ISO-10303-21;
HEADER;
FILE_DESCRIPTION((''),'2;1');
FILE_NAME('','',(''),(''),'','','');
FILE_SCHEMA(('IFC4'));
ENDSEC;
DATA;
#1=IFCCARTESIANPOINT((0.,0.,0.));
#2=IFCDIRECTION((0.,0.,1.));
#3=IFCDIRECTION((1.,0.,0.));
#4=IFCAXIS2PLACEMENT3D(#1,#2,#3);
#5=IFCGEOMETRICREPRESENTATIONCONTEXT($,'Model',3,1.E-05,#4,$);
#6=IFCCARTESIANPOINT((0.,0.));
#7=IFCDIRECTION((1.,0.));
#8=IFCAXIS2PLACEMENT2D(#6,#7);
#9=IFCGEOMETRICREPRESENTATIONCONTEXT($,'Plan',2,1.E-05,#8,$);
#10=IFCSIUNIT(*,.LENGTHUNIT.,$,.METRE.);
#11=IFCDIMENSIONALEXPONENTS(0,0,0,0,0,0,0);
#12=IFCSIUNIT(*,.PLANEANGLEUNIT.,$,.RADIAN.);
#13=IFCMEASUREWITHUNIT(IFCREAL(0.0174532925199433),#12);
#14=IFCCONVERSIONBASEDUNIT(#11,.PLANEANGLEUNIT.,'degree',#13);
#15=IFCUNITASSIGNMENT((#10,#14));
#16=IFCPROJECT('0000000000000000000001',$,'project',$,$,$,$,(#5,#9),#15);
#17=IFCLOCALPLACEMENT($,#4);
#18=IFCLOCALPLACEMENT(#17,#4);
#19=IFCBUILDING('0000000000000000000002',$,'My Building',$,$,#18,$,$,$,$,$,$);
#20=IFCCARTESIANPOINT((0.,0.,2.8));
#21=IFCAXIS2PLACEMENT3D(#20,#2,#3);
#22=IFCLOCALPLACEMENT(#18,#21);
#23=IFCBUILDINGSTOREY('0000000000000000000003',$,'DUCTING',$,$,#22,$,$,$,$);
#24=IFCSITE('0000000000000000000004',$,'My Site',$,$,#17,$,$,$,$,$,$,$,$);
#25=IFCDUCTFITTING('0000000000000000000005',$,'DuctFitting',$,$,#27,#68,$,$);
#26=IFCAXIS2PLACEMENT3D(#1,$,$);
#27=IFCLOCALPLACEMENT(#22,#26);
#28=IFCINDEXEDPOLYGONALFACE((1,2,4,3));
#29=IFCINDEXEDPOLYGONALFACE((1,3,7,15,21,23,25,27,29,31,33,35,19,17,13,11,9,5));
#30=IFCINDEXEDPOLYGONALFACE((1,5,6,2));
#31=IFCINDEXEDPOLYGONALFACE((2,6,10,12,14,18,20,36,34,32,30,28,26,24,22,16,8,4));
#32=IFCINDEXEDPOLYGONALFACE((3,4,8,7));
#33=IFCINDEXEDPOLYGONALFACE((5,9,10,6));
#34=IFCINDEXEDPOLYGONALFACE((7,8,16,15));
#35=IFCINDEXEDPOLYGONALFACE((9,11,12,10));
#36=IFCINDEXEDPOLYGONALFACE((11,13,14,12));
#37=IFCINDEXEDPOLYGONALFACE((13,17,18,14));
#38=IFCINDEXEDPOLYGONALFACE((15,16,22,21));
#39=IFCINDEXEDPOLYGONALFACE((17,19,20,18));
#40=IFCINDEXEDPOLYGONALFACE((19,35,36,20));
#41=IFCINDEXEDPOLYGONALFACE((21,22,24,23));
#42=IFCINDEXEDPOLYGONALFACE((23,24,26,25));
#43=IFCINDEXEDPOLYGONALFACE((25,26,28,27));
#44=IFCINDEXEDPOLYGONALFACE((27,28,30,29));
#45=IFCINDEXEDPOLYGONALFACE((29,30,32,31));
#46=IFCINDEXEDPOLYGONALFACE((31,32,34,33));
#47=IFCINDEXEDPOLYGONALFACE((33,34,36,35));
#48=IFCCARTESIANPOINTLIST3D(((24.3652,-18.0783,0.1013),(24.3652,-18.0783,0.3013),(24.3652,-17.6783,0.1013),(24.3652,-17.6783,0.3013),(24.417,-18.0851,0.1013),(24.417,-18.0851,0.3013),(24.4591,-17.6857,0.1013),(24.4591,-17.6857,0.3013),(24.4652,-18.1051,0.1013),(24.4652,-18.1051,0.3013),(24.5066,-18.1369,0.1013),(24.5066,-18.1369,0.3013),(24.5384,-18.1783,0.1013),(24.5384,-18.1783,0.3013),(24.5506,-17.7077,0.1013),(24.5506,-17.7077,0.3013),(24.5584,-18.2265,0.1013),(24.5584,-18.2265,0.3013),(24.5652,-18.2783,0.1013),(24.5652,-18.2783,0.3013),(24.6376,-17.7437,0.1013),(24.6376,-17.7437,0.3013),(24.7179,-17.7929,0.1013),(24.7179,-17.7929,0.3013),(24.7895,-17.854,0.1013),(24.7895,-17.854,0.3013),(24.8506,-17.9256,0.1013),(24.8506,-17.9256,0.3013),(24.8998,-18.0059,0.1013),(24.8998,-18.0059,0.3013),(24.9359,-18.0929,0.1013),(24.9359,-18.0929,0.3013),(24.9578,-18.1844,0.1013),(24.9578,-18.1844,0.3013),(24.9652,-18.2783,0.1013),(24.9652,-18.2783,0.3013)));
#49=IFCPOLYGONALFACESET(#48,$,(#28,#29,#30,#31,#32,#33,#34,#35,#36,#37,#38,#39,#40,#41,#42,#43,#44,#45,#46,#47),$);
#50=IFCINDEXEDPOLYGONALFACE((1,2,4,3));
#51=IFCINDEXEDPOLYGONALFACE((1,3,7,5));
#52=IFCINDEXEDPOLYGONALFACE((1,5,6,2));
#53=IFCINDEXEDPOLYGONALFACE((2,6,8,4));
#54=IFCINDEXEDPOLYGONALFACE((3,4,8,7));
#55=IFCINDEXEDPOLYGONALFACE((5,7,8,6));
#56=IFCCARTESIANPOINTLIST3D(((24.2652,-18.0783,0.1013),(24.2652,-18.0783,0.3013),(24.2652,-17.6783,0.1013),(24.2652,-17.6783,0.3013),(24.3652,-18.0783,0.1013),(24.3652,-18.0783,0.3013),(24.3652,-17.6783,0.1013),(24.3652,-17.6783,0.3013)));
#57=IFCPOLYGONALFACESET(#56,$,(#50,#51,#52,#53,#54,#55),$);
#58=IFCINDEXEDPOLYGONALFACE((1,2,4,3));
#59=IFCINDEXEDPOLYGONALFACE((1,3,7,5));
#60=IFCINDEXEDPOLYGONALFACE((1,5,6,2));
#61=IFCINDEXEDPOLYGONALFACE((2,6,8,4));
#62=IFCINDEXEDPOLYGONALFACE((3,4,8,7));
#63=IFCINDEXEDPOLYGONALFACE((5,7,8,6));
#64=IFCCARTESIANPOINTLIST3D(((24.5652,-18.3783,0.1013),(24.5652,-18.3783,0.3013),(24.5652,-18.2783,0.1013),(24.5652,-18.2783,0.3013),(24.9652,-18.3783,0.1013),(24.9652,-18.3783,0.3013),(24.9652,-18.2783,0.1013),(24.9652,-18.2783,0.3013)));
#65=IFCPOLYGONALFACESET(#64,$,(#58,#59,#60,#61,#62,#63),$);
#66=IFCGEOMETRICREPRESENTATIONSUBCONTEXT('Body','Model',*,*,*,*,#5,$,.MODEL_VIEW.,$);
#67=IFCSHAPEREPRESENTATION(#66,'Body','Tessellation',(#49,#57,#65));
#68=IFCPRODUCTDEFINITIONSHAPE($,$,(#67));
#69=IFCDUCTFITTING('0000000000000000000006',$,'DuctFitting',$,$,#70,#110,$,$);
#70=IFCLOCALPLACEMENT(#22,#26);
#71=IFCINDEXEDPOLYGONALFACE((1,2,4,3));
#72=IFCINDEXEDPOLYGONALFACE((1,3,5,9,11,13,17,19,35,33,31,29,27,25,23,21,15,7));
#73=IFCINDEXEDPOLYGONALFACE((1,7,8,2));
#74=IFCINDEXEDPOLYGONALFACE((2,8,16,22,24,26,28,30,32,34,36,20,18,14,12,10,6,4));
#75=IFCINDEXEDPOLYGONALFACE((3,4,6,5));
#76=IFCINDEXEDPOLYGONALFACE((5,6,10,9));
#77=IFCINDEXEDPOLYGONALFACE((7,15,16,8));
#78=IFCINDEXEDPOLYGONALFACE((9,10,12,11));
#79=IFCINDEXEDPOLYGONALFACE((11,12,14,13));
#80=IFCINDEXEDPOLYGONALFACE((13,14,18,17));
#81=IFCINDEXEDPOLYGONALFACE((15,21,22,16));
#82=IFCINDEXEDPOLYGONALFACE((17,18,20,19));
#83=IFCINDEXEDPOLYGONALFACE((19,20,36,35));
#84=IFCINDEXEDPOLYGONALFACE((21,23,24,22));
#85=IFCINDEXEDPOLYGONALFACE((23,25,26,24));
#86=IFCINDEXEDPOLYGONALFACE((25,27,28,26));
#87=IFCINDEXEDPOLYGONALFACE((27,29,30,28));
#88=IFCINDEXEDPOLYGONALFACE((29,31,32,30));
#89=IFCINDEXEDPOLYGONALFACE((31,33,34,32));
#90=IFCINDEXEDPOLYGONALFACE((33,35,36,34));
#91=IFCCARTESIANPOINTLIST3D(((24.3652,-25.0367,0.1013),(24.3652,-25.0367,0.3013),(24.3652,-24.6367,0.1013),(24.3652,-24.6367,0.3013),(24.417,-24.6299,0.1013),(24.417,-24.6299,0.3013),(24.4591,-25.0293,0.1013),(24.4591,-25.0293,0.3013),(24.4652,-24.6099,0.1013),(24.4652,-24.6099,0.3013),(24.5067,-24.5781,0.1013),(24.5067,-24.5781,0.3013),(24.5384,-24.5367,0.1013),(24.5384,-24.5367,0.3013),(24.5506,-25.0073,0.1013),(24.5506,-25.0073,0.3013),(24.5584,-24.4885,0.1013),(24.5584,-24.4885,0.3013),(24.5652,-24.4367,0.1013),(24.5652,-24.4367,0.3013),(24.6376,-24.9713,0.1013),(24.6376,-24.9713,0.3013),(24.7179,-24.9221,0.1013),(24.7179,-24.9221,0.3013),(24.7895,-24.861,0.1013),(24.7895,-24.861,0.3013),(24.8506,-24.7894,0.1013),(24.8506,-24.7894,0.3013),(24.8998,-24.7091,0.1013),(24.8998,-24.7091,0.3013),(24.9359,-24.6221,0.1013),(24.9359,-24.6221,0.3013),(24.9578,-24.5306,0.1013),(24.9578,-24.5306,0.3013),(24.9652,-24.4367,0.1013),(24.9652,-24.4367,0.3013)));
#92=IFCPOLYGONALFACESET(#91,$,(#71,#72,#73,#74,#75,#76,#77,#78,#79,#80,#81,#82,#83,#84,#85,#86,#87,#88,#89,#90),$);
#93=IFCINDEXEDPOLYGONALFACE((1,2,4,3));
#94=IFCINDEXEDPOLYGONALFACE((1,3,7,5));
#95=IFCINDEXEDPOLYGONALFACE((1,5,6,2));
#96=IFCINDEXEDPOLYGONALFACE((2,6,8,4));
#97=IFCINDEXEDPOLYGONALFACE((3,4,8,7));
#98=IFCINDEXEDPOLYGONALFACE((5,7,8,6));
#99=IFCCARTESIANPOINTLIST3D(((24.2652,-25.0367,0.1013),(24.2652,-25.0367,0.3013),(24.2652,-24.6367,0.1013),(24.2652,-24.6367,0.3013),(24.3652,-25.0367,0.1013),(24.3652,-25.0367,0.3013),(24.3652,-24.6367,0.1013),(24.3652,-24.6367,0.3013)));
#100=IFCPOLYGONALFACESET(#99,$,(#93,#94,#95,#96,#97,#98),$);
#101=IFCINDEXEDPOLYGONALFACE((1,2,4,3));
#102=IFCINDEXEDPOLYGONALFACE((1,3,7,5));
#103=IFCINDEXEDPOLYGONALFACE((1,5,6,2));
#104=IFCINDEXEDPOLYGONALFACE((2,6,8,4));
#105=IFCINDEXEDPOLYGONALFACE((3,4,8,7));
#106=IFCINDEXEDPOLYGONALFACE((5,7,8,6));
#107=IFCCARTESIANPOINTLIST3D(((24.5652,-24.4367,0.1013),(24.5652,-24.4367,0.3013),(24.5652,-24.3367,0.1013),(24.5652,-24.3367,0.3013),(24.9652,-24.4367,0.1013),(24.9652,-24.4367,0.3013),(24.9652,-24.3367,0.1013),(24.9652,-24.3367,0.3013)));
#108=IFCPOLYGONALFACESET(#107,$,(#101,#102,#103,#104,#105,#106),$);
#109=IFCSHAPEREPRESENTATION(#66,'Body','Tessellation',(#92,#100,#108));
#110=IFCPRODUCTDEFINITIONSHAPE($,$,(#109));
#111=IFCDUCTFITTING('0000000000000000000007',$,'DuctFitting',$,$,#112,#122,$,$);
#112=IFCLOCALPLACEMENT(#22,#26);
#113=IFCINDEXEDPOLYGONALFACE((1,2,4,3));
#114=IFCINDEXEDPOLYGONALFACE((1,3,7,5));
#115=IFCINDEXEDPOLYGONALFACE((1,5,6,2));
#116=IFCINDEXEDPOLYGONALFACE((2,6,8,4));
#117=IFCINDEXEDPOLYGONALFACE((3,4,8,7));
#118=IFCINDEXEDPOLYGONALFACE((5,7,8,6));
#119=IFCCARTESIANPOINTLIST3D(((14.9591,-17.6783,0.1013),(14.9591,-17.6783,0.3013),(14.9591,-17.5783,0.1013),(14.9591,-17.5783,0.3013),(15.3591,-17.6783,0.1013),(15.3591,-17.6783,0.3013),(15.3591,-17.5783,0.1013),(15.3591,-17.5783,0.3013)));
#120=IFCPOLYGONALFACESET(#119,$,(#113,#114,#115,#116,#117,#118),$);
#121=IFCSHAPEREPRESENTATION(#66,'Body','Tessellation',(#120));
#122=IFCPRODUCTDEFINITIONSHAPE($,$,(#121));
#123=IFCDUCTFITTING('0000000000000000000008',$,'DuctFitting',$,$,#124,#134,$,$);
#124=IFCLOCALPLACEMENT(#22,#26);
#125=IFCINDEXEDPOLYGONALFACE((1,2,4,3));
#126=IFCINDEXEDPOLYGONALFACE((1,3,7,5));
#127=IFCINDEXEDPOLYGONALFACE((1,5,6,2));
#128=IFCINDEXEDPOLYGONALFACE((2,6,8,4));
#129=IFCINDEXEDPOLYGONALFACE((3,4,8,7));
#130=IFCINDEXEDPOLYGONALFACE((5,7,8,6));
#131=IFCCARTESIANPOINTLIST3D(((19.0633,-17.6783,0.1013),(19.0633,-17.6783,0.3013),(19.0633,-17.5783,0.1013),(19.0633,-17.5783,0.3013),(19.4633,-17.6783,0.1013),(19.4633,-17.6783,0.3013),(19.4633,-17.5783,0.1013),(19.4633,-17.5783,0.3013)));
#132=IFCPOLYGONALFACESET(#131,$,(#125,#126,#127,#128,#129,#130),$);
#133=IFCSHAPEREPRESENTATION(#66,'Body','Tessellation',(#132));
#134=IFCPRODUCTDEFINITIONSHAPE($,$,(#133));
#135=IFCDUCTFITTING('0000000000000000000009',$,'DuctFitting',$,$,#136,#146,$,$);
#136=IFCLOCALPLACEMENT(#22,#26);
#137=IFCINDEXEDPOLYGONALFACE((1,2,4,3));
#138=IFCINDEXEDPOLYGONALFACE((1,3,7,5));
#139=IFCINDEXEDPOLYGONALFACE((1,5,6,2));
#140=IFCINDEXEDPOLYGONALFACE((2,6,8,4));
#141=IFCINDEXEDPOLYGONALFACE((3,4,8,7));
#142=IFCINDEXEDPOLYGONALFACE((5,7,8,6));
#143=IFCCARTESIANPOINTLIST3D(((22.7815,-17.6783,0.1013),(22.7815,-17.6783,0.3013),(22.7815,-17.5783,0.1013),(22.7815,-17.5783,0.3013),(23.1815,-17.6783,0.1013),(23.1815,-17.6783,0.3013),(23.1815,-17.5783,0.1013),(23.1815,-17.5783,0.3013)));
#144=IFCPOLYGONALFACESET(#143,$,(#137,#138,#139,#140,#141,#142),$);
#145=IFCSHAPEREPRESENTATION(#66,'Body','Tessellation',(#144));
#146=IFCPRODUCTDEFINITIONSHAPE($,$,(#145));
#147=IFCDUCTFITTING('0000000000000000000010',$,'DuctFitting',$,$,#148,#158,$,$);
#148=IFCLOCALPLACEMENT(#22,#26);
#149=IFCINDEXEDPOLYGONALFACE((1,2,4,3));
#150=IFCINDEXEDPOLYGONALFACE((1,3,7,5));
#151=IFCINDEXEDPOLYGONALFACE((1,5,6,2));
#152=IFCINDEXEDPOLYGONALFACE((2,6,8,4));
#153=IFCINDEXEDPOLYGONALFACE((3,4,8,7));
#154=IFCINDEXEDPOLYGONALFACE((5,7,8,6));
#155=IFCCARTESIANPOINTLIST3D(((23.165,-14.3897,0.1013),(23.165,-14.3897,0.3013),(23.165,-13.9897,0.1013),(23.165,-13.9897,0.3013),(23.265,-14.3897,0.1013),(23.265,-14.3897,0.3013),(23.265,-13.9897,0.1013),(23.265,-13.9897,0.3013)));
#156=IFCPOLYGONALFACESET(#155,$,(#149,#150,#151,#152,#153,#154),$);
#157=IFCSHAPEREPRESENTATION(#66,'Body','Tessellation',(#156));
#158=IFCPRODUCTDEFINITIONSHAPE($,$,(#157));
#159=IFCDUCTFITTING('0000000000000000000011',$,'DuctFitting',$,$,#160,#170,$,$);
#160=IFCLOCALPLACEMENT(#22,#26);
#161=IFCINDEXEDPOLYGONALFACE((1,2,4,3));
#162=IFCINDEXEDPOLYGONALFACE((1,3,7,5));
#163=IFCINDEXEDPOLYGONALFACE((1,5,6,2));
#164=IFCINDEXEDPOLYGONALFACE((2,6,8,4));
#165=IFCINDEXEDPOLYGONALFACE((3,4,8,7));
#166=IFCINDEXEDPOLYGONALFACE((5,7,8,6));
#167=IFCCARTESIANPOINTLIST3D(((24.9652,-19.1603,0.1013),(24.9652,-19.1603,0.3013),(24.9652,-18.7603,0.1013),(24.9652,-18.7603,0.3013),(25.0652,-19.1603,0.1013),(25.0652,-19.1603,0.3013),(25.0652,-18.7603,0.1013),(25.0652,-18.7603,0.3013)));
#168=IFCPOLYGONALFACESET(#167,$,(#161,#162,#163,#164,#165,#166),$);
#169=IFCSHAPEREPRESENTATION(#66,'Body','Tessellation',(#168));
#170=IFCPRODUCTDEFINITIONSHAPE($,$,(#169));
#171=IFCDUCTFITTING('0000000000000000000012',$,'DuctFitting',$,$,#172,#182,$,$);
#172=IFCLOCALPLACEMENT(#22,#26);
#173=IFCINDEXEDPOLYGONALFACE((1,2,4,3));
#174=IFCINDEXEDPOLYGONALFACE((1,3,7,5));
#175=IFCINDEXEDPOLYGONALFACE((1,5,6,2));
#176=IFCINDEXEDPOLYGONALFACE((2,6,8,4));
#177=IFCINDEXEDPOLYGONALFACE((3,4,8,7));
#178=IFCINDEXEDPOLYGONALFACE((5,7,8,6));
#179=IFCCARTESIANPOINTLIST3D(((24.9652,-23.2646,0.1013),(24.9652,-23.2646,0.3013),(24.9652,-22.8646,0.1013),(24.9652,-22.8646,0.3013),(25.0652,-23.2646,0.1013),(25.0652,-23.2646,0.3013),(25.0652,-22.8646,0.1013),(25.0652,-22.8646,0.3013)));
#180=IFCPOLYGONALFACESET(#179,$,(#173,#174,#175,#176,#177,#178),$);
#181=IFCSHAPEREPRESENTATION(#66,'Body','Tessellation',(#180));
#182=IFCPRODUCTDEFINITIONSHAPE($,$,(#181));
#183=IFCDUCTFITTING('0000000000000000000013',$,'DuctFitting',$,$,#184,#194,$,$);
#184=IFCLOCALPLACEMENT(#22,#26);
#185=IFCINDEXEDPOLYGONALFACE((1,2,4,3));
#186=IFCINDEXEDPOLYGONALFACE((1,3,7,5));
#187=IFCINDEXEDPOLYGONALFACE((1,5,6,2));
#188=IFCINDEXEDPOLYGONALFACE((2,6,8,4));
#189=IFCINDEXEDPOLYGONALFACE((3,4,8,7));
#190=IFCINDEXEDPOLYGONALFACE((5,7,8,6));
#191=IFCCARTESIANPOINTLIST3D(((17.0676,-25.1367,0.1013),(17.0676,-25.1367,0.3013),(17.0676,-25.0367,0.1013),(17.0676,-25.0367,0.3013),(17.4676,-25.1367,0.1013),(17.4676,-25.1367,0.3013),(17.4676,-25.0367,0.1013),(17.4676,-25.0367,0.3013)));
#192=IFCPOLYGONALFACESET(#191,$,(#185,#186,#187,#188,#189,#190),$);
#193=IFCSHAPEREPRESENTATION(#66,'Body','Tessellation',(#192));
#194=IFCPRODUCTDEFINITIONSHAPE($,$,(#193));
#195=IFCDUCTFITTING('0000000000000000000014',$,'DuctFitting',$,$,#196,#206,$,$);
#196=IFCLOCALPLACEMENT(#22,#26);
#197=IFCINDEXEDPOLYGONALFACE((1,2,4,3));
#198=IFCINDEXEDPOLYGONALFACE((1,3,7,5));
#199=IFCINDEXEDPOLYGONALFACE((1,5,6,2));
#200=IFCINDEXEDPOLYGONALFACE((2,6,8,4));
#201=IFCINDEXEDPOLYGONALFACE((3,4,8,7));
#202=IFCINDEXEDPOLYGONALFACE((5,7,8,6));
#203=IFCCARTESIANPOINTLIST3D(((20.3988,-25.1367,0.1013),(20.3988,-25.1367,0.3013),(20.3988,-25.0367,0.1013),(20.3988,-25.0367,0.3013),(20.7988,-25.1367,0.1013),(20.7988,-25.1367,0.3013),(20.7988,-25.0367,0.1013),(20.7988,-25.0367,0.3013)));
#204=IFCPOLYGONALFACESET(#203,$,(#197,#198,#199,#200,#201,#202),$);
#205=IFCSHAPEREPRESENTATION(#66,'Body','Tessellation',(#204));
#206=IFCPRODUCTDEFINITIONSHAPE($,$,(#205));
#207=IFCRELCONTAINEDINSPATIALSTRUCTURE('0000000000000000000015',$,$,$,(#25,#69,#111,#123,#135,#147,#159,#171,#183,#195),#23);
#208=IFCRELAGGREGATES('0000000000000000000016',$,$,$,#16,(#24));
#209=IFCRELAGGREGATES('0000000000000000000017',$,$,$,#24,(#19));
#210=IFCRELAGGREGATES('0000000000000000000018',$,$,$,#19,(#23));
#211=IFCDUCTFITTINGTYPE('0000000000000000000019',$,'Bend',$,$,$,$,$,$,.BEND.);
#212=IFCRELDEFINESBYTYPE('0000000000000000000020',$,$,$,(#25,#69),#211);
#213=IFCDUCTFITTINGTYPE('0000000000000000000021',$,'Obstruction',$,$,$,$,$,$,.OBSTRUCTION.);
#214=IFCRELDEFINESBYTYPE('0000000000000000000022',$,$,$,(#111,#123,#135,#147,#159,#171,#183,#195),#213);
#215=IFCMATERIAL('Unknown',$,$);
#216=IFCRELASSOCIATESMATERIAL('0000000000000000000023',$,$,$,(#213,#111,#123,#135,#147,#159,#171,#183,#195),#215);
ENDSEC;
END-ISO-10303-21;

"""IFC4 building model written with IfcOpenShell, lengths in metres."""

from ifc_helpers import new_model, entity, si_unit, converted_unit, frame, origin_with_axes, origin_2d_with_axis, place, context, subcontext, project, spatial, line, arc, indexed_curve, rectangle, outline, extrude, source, transform, mapped, material, material_profile, profile_set, profile_usage, type_object, type_shapes, element, save


model = new_model("IFC4")

# Units and contexts
model_context = context("Model", 3, precision=1e-05, world=origin_with_axes())
plan_context = context("Plan", 2, precision=1e-05, world=origin_2d_with_axis())
body_context = subcontext(model_context, "Body", "Model", "MODEL_VIEW")
ifc_project = project(units=[si_unit("LENGTHUNIT", "METRE"), converted_unit("PLANEANGLEUNIT", "degree", entity("IfcReal", 0.0174532925199433), si_unit("PLANEANGLEUNIT", "RADIAN"), dimensions=[0, 0, 0, 0, 0, 0, 0])], contexts=[model_context, plan_context])

# Site, building, storey
site_placement = place(None, origin_with_axes())
site = spatial("IfcSite", under=ifc_project, at=site_placement, Name="My Site")
building_placement = place(site_placement, origin_with_axes())
building = spatial("IfcBuilding", under=site, at=building_placement, Name="My Building")
storey_placement = place(building_placement, frame((0.0, 0.0, 2.8), z_axis=(0.0, 0.0, 1.0), x_axis=(1.0, 0.0, 0.0)))
storey = spatial("IfcBuildingStorey", under=building, at=storey_placement, Name="DUCTING")

# Shared definitions
ifc_material = material(Name="Unknown")

# Duct fittings
duct_fitting_type_1 = type_object("IfcDuctFittingType", Name="Bend", PredefinedType="BEND")
shared_shape = source(origin_with_axes(), body_context, "Body", "SweptSolid", [
    extrude(outline(indexed_curve([(-0.2, 0.0), (-0.2586, -0.1414), (-0.4, -0.2), (-0.4, -0.6), (0.0243, -0.4243), (0.2, 0.0)], segments=[arc(1, 2, 3), line(3, 4), arc(4, 5, 6), line(6, 1)])), frame((0.0, -0.1, -0.1), z_axis=(0.0, -1.0, 0.0), x_axis=(1.0, 0.0, 0.0)), (0.0, 0.0, -1.0), 0.2),
    extrude(rectangle(XDim=0.4, YDim=0.2), origin_with_axes(), (0.0, 0.0, -1.0), 0.1),
    extrude(rectangle(XDim=0.4, YDim=0.2), frame((-0.4, 0.0, -0.5), z_axis=(-1.0, 0.0, 0.000001), x_axis=(-0.000001, 0.0, -1.0)), (0.0, 0.0, 1.0), 0.1),
])
type_shapes(duct_fitting_type_1, [shared_shape])
for number, where, z_axis, x_axis, name in (
    (1, (24.2652, -17.8783, 0.2013), (-1.0, 0.0, 0.0), (0.0, 1.0, 0.0), "DuctFitting"),
    (2, (24.2652, -24.8367, 0.2013), (-1.0, 0.000001, 0.0), (-0.000001, -1.0, 0.0), "DuctFitting"),
):
    element("IfcDuctFitting", number, at=place(storey_placement, frame(where, z_axis=z_axis, x_axis=x_axis)), inside=storey, type_object=duct_fitting_type_1, Name=name, context=body_context, shape_type="MappedRepresentation", body=[
        mapped(shared_shape, transform((0.0, 0.0, 0.0), x_axis=(1.0, 0.0, 0.0), y_axis=(0.0, 1.0, 0.0), z_axis=(0.0, 0.0, 1.0), scale=1.0)),
    ])
ifc_material_profile_1 = material_profile(ifc_material, rectangle(XDim=0.4, YDim=0.2))
ifc_profile_set_1 = profile_set([ifc_material_profile_1])
ifc_profile_usage_1 = profile_usage(ifc_profile_set_1, cardinal=5)
duct_fitting_type_2 = type_object("IfcDuctFittingType", Name="Obstruction", PredefinedType="OBSTRUCTION", material=ifc_profile_set_1)
duct_fitting_1_placement = place(storey_placement, frame((15.1591, -17.6783, 0.2013), z_axis=(0.0, 1.0, 0.0), x_axis=(-1.0, 0.0, 0.0)))
element("IfcDuctFitting", 3, at=duct_fitting_1_placement, inside=storey, type_object=duct_fitting_type_2, material=ifc_profile_usage_1, Name="DuctFitting", context=body_context, shape_type="SweptSolid", body=[
    extrude(rectangle(XDim=0.4, YDim=0.2), origin_with_axes(), (0.0, 0.0, 1.0), 0.1),
])
ifc_profile_usage_2 = profile_usage(ifc_profile_set_1, cardinal=5)
duct_fitting_2_placement = place(storey_placement, frame((19.2633, -17.6783, 0.2013), z_axis=(0.0, 1.0, 0.0), x_axis=(-1.0, 0.0, 0.0)))
element("IfcDuctFitting", 4, at=duct_fitting_2_placement, inside=storey, type_object=duct_fitting_type_2, material=ifc_profile_usage_2, Name="DuctFitting", context=body_context, shape_type="SweptSolid", body=[
    extrude(rectangle(XDim=0.4, YDim=0.2), origin_with_axes(), (0.0, 0.0, 1.0), 0.1),
])
ifc_profile_usage_3 = profile_usage(ifc_profile_set_1, cardinal=5)
duct_fitting_3_placement = place(storey_placement, frame((22.9815, -17.6783, 0.2013), z_axis=(0.0, 1.0, 0.0), x_axis=(-1.0, 0.0, 0.0)))
element("IfcDuctFitting", 5, at=duct_fitting_3_placement, inside=storey, type_object=duct_fitting_type_2, material=ifc_profile_usage_3, Name="DuctFitting", context=body_context, shape_type="SweptSolid", body=[
    extrude(rectangle(XDim=0.4, YDim=0.2), origin_with_axes(), (0.0, 0.0, 1.0), 0.1),
])
ifc_profile_usage_4 = profile_usage(ifc_profile_set_1, cardinal=5)
duct_fitting_4_placement = place(storey_placement, frame((23.165, -14.1897, 0.2013), z_axis=(1.0, -0.000001, 0.000001), x_axis=(0.000001, 1.0, 0.0)))
element("IfcDuctFitting", 6, at=duct_fitting_4_placement, inside=storey, type_object=duct_fitting_type_2, material=ifc_profile_usage_4, Name="DuctFitting", context=body_context, shape_type="SweptSolid", body=[
    extrude(rectangle(XDim=0.4, YDim=0.2), origin_with_axes(), (0.0, 0.0, 1.0), 0.1),
])
ifc_profile_usage_5 = profile_usage(ifc_profile_set_1, cardinal=5)
duct_fitting_5_placement = place(storey_placement, frame((24.9652, -18.9603, 0.2013), z_axis=(1.0, 0.0, 0.0), x_axis=(0.0, 1.0, 0.0)))
element("IfcDuctFitting", 7, at=duct_fitting_5_placement, inside=storey, type_object=duct_fitting_type_2, material=ifc_profile_usage_5, Name="DuctFitting", context=body_context, shape_type="SweptSolid", body=[
    extrude(rectangle(XDim=0.4, YDim=0.2), origin_with_axes(), (0.0, 0.0, 1.0), 0.1),
])
ifc_profile_usage_6 = profile_usage(ifc_profile_set_1, cardinal=5)
duct_fitting_6_placement = place(storey_placement, frame((24.9652, -23.0646, 0.2013), z_axis=(1.0, 0.0, 0.0), x_axis=(0.0, 1.0, 0.0)))
element("IfcDuctFitting", 8, at=duct_fitting_6_placement, inside=storey, type_object=duct_fitting_type_2, material=ifc_profile_usage_6, Name="DuctFitting", context=body_context, shape_type="SweptSolid", body=[
    extrude(rectangle(XDim=0.4, YDim=0.2), origin_with_axes(), (0.0, 0.0, 1.0), 0.1),
])
ifc_profile_usage_7 = profile_usage(ifc_profile_set_1, cardinal=5)
duct_fitting_7_placement = place(storey_placement, frame((17.2676, -25.0367, 0.2013), z_axis=(0.0, -1.0, 0.0), x_axis=(1.0, 0.0, 0.0)))
element("IfcDuctFitting", 9, at=duct_fitting_7_placement, inside=storey, type_object=duct_fitting_type_2, material=ifc_profile_usage_7, Name="DuctFitting", context=body_context, shape_type="SweptSolid", body=[
    extrude(rectangle(XDim=0.4, YDim=0.2), origin_with_axes(), (0.0, 0.0, 1.0), 0.1),
])
ifc_profile_usage_8 = profile_usage(ifc_profile_set_1, cardinal=5)
duct_fitting_8_placement = place(storey_placement, frame((20.5988, -25.0367, 0.2013), z_axis=(0.0, -1.0, 0.0), x_axis=(1.0, 0.0, 0.0)))
element("IfcDuctFitting", 10, at=duct_fitting_8_placement, inside=storey, type_object=duct_fitting_type_2, material=ifc_profile_usage_8, Name="DuctFitting", context=body_context, shape_type="SweptSolid", body=[
    extrude(rectangle(XDim=0.4, YDim=0.2), origin_with_axes(), (0.0, 0.0, 1.0), 0.1),
])

save(model, "model.ifc")
